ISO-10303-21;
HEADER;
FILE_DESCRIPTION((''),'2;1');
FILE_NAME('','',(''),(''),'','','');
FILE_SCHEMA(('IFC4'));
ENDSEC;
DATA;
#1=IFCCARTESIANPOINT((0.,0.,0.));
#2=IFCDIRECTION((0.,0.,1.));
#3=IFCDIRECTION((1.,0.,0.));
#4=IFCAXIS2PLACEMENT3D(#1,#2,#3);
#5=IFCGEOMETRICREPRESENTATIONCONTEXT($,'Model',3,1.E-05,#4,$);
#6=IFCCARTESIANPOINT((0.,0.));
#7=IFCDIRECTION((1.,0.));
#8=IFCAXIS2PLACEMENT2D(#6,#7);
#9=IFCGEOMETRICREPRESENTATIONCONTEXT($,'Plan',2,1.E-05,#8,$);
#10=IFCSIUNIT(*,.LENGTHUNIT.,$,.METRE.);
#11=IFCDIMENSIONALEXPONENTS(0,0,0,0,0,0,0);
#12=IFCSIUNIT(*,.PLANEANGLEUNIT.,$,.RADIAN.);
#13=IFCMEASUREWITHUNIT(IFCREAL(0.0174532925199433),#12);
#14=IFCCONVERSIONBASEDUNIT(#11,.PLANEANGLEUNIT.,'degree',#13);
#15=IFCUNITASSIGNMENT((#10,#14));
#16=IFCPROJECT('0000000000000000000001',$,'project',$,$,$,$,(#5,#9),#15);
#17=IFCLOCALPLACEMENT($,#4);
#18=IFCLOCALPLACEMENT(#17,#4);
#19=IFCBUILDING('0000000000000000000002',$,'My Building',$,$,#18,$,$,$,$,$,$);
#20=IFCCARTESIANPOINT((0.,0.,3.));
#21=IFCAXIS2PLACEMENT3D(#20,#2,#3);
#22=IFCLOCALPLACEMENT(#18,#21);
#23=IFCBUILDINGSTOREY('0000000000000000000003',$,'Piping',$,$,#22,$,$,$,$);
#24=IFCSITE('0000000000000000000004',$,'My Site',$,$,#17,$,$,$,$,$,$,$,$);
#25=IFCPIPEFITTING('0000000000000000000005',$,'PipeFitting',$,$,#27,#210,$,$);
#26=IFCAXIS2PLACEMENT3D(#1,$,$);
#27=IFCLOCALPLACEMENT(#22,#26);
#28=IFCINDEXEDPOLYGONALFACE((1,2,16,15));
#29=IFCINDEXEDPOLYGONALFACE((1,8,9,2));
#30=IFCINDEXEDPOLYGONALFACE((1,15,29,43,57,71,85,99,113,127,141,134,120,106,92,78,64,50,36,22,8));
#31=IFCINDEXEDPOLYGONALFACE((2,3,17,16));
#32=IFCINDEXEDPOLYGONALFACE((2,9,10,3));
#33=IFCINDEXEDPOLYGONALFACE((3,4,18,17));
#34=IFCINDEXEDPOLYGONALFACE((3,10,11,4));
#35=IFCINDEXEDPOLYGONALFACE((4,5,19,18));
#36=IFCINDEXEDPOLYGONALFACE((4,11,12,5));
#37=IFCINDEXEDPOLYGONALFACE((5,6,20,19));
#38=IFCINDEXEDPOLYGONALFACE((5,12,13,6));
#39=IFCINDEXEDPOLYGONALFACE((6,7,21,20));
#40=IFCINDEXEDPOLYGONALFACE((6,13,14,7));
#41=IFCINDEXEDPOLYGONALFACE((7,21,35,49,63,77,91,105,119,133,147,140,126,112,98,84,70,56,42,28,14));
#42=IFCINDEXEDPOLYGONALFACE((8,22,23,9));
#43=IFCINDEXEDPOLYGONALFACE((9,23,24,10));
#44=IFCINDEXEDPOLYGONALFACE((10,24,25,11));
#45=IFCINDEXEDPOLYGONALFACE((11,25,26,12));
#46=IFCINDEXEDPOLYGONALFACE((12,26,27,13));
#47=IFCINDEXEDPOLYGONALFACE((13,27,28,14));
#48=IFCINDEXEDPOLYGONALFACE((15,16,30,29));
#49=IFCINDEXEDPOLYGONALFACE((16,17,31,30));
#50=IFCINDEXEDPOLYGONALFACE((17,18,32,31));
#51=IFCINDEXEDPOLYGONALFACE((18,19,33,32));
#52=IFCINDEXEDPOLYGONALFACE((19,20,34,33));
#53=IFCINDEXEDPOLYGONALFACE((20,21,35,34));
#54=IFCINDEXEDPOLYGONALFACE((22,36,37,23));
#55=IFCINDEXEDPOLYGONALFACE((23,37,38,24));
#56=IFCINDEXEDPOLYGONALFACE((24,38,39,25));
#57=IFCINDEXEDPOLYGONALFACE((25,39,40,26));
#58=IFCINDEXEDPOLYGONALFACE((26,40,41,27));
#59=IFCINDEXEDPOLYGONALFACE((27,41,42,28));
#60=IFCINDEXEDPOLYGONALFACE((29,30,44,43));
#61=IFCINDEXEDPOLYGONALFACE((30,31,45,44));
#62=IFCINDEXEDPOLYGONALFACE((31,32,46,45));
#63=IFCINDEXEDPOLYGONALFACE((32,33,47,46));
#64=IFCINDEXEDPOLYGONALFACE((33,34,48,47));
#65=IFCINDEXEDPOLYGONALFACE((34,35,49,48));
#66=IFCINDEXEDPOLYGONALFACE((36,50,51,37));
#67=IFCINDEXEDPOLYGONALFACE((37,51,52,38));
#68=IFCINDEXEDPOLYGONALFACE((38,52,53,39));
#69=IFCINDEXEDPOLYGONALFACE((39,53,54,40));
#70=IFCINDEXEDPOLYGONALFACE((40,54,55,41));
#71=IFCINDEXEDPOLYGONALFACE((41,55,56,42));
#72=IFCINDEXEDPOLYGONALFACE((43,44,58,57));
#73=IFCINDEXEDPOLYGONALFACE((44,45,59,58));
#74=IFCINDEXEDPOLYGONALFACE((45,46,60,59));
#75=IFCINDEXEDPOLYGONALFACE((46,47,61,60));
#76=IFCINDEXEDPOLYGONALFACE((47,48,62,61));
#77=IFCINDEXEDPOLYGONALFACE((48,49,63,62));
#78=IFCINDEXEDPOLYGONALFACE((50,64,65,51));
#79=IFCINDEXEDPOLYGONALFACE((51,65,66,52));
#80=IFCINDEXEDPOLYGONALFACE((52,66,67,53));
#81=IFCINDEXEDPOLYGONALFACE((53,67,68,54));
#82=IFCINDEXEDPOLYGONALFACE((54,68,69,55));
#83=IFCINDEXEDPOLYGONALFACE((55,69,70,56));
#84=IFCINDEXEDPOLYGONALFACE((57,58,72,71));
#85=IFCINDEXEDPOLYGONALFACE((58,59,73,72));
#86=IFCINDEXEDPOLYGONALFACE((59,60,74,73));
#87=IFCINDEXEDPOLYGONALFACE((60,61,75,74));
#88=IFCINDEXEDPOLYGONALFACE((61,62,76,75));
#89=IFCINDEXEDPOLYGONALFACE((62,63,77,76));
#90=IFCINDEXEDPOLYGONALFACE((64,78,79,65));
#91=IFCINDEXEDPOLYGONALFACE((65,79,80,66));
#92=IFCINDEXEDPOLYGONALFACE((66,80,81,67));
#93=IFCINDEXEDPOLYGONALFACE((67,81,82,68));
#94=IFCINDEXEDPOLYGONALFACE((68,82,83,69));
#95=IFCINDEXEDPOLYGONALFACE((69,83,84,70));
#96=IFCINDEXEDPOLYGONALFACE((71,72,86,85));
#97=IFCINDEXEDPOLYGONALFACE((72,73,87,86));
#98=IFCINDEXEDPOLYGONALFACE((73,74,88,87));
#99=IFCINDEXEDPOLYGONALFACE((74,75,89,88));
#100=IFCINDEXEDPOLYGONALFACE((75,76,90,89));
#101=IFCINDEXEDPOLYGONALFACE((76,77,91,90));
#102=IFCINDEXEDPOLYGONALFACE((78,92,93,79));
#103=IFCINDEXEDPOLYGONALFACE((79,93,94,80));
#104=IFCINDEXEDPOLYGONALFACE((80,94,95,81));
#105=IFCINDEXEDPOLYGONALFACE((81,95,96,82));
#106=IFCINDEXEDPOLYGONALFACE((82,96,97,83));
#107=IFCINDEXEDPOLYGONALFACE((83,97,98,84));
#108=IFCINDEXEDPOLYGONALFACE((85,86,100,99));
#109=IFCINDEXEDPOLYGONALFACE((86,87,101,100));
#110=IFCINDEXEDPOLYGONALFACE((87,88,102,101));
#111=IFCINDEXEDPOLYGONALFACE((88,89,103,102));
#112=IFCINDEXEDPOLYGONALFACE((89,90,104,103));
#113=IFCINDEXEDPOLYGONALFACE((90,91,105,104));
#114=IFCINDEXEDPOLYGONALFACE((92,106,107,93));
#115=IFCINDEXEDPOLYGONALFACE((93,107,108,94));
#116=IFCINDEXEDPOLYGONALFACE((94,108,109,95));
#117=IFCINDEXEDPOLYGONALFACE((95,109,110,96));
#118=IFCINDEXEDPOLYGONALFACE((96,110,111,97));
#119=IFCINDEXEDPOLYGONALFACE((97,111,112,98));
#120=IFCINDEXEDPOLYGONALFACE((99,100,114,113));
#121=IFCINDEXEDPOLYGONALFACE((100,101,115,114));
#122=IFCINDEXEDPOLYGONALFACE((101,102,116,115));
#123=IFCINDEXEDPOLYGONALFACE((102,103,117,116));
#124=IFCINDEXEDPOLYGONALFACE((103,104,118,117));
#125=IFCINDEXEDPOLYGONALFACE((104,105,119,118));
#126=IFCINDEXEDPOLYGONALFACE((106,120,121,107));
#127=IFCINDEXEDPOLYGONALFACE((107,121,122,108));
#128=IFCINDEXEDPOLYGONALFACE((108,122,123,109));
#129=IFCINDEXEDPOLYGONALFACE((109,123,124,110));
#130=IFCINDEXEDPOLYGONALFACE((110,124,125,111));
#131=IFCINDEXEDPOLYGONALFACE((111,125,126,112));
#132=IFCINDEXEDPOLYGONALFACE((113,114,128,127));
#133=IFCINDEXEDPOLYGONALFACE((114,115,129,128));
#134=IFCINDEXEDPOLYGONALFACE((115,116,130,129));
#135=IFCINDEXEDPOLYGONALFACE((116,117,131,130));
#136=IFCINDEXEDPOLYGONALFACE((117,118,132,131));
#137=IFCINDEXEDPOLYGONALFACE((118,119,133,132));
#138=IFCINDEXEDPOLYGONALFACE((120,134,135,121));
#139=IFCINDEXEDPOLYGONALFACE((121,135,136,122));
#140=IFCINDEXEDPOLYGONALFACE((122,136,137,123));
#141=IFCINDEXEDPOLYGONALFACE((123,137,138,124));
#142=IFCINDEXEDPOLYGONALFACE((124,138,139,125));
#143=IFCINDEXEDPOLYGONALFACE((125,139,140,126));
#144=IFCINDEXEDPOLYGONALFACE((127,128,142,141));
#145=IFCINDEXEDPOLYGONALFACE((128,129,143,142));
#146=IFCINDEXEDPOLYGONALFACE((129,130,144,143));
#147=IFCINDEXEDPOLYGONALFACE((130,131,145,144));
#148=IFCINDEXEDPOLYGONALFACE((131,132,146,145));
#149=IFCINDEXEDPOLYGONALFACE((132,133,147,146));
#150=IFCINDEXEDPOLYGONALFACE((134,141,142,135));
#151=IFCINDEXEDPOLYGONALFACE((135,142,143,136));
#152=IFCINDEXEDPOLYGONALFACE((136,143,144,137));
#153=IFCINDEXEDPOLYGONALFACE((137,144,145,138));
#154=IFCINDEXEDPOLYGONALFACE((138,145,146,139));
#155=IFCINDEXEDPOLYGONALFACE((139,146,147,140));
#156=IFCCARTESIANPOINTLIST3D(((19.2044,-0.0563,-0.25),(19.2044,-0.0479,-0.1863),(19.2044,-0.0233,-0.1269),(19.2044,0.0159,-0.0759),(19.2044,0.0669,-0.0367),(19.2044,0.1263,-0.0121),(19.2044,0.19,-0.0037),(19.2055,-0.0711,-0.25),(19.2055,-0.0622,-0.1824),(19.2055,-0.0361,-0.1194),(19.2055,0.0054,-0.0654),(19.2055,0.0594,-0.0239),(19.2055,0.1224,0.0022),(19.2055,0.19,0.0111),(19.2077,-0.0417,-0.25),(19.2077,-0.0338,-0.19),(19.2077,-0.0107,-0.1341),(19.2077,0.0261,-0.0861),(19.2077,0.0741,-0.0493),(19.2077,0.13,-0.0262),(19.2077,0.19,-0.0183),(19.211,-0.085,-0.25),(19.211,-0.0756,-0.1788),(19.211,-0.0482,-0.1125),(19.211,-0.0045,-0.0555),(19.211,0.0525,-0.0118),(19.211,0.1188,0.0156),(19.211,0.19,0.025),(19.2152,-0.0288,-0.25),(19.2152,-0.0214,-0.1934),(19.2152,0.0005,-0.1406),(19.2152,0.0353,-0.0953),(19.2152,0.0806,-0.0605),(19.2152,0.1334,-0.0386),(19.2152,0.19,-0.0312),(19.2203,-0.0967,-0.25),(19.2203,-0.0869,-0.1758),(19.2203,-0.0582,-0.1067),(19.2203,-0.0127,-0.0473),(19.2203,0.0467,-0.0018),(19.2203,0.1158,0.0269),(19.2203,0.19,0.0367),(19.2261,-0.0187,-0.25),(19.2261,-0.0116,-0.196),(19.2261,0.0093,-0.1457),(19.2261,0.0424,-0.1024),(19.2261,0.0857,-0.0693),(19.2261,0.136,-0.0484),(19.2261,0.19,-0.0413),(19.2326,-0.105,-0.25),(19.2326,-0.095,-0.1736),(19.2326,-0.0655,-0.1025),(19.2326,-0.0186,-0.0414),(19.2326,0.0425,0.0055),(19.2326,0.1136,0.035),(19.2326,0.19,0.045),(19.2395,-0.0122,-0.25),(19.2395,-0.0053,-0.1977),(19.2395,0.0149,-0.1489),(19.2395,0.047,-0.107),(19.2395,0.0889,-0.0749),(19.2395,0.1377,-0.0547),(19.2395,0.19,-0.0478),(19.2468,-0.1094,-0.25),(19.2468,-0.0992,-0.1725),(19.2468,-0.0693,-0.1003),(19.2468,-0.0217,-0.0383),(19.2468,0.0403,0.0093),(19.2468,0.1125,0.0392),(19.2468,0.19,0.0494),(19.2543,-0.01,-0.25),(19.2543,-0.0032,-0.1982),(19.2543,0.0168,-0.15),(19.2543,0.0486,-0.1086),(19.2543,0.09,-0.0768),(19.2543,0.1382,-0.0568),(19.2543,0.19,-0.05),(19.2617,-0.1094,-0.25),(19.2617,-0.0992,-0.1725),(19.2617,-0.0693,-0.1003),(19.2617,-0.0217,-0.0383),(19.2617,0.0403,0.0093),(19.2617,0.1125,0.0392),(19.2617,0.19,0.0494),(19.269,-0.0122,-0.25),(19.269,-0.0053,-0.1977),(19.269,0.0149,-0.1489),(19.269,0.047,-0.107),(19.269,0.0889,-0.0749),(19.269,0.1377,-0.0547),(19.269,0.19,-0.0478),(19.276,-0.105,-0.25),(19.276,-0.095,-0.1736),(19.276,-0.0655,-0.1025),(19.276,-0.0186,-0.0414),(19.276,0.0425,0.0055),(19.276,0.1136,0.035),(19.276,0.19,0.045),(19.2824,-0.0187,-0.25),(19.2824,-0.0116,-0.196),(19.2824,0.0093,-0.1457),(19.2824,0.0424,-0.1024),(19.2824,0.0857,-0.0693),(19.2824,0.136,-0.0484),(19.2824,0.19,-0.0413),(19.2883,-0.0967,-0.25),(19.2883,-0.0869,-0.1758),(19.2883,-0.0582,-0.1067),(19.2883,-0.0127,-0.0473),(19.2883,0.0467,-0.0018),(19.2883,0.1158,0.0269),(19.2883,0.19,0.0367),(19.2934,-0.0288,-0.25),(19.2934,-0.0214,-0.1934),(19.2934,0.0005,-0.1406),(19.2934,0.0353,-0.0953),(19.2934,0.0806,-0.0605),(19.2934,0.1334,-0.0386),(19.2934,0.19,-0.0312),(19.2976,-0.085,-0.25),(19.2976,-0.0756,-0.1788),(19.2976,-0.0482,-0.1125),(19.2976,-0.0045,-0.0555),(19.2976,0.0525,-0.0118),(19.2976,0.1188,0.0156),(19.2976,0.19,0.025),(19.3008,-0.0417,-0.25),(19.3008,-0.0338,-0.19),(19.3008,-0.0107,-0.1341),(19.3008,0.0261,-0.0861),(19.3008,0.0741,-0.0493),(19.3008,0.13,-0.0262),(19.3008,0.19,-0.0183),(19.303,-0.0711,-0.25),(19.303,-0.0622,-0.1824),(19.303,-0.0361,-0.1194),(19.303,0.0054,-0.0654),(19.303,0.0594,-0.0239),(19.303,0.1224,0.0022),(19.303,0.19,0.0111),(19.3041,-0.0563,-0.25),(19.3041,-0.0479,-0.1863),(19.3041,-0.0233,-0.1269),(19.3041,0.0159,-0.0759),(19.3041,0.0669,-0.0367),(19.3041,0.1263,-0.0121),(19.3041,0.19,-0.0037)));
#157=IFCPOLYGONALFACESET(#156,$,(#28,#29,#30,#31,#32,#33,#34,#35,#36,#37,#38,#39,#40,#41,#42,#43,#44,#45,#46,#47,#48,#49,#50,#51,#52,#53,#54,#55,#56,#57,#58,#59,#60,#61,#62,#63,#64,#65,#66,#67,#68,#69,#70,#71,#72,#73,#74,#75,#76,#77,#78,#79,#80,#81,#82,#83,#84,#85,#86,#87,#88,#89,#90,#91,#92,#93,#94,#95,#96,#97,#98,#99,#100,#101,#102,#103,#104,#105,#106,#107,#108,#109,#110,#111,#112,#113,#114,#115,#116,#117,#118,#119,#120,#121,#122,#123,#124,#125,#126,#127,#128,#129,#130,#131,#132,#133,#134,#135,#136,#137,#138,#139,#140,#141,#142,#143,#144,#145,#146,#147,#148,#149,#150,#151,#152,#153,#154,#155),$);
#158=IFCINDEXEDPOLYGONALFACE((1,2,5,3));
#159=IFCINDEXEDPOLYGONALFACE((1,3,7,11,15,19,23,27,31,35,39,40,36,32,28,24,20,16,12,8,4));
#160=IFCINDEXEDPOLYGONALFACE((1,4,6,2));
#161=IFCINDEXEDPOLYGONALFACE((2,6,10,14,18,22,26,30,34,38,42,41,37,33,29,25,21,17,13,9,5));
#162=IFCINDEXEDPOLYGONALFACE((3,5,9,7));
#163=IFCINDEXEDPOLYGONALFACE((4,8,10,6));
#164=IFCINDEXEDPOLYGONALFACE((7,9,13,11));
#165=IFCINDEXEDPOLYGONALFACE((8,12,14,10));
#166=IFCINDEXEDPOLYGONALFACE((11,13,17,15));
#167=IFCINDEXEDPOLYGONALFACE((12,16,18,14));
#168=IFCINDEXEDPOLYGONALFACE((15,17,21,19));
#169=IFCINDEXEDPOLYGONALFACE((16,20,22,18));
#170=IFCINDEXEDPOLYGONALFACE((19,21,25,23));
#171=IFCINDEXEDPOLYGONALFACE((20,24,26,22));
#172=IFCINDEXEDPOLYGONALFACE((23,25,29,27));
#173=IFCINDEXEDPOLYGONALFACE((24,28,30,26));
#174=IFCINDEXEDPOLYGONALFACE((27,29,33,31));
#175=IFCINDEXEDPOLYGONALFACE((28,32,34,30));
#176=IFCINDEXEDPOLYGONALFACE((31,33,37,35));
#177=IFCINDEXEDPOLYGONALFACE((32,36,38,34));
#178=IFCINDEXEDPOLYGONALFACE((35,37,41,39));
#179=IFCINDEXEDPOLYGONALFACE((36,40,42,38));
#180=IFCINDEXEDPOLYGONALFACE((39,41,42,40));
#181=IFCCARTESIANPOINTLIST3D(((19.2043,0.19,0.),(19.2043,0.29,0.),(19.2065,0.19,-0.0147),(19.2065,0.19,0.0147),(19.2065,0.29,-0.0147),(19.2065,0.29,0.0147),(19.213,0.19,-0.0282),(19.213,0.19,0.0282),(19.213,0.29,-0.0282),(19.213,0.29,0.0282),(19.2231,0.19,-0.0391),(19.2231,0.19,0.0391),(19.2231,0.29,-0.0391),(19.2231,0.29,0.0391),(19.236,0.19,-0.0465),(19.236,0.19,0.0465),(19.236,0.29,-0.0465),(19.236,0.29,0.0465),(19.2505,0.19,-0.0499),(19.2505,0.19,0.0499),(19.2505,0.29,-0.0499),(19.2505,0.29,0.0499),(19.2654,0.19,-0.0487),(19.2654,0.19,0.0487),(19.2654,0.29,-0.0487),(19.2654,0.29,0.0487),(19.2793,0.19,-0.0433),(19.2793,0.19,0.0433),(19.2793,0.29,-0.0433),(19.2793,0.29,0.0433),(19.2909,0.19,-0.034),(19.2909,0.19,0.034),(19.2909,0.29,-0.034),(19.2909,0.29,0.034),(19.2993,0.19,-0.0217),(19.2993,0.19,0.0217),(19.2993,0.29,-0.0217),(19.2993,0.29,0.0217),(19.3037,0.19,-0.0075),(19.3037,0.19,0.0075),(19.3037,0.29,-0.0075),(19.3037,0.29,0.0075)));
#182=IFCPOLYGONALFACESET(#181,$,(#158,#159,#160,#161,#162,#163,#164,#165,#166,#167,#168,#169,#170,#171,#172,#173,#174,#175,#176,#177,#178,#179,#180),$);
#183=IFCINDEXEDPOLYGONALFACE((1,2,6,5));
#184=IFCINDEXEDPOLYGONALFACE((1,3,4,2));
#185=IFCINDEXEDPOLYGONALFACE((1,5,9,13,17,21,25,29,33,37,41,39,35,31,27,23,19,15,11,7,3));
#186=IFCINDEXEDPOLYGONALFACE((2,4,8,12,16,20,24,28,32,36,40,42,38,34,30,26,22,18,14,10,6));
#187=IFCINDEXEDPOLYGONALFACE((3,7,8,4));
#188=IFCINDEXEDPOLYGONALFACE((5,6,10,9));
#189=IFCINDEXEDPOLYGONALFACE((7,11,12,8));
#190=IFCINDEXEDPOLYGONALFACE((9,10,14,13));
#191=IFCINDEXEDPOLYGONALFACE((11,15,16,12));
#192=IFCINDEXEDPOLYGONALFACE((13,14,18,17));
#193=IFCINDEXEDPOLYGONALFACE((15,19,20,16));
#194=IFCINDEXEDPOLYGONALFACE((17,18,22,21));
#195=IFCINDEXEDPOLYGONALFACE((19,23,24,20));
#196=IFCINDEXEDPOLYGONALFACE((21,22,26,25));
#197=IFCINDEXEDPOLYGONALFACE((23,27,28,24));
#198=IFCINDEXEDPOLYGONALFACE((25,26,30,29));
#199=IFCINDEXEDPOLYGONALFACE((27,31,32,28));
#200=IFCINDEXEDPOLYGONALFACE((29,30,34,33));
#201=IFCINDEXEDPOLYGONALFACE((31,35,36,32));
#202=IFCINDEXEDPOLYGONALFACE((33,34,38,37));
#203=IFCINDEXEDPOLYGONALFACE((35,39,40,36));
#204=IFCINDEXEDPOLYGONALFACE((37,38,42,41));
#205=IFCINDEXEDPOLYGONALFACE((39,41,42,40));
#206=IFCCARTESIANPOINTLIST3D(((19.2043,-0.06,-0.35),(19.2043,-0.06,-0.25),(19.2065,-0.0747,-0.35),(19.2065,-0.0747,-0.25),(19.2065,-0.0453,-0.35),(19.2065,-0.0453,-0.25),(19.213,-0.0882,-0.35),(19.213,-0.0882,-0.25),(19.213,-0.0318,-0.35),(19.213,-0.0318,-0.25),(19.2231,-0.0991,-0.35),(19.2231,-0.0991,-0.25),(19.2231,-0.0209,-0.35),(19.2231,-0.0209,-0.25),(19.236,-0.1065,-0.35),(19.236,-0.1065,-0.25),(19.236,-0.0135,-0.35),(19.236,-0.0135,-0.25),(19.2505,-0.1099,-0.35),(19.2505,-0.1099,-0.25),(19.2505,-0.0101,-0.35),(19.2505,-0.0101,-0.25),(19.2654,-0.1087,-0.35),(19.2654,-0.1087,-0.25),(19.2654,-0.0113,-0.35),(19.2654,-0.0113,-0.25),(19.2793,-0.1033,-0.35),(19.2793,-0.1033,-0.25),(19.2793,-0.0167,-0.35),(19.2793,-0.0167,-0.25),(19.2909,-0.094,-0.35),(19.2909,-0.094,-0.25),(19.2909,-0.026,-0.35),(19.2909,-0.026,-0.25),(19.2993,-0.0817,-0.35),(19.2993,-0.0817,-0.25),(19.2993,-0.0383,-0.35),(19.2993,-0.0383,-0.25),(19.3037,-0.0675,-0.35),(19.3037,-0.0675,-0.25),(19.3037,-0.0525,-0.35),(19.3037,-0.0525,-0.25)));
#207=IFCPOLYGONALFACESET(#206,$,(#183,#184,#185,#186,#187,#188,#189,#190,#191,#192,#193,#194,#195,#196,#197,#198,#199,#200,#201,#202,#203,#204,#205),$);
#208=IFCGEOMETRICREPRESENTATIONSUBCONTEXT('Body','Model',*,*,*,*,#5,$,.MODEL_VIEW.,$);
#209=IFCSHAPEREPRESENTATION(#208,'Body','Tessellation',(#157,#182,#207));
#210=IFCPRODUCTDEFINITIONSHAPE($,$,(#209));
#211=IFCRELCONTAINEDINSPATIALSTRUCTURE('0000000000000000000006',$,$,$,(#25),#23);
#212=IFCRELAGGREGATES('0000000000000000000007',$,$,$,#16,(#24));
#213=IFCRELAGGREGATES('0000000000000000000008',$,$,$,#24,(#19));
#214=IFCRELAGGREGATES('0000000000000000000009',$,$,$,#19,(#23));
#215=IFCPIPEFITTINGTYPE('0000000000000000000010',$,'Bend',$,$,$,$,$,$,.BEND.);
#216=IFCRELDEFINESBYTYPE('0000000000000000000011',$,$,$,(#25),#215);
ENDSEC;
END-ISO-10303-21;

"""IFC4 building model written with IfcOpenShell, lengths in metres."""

from ifc_helpers import new_model, entity, si_unit, converted_unit, frame, origin_with_axes, origin_2d_with_axis, place, context, subcontext, project, spatial, circle, extrude, source, transform, mapped, type_object, type_shapes, element, save


model = new_model("IFC4")

# Units and contexts
model_context = context("Model", 3, precision=1e-05, world=origin_with_axes())
plan_context = context("Plan", 2, precision=1e-05, world=origin_2d_with_axis())
body_context = subcontext(model_context, "Body", "Model", "MODEL_VIEW")
ifc_project = project(units=[si_unit("LENGTHUNIT", "METRE"), converted_unit("PLANEANGLEUNIT", "degree", entity("IfcReal", 0.0174532925199433), si_unit("PLANEANGLEUNIT", "RADIAN"), dimensions=[0, 0, 0, 0, 0, 0, 0])], contexts=[model_context, plan_context])

# Site, building, storey
site_placement = place(None, origin_with_axes())
site = spatial("IfcSite", under=ifc_project, at=site_placement, Name="My Site")
building_placement = place(site_placement, origin_with_axes())
building = spatial("IfcBuilding", under=site, at=building_placement, Name="My Building")
storey_placement = place(building_placement, frame((0.0, 0.0, 3.0), z_axis=(0.0, 0.0, 1.0), x_axis=(1.0, 0.0, 0.0)))
storey = spatial("IfcBuildingStorey", under=building, at=storey_placement, Name="Piping")

# Pipe fitting
pipe_fitting_type_1 = type_object("IfcPipeFittingType", Name="Bend", PredefinedType="BEND")
shared_shape = source(origin_with_axes(), body_context, "Body", "SolidModel", [
    entity("IfcSweptDiskSolid", entity("IfcIndexedPolyCurve", entity("IfcCartesianPointList3D", [[0.0, 0.0, -0.1], [0.0, -0.0732, -0.2768], [0.0, -0.25, -0.35]]), [entity("IfcArcIndex", [1, 2, 3])]), 0.05),
    extrude(circle(Radius=0.05), origin_with_axes(), (0.0, 0.0, -1.0), 0.1),
    extrude(circle(Radius=0.05), frame((0.0, -0.25, -0.35), z_axis=(0.0, -1.0, 0.0), x_axis=(1.0, 0.0, 0.0)), (0.0, 0.0, 1.0), 0.1),
])
type_shapes(pipe_fitting_type_1, [shared_shape])
for number, where, z_axis, x_axis, name in (
    (1, (19.2543, 0.29, 0.0), (0.0, 1.0, 0.0), (-1.0, 0.0, 0.0), "PipeFitting"),
):
    element("IfcPipeFitting", number, at=place(storey_placement, frame(where, z_axis=z_axis, x_axis=x_axis)), inside=storey, type_object=pipe_fitting_type_1, Name=name, context=body_context, shape_type="MappedRepresentation", body=[
        mapped(shared_shape, transform((0.0, 0.0, 0.0), x_axis=(1.0, 0.0, 0.0), y_axis=(0.0, 1.0, 0.0), z_axis=(0.0, 0.0, 1.0), scale=1.0)),
    ])

save(model, "model.ifc")
